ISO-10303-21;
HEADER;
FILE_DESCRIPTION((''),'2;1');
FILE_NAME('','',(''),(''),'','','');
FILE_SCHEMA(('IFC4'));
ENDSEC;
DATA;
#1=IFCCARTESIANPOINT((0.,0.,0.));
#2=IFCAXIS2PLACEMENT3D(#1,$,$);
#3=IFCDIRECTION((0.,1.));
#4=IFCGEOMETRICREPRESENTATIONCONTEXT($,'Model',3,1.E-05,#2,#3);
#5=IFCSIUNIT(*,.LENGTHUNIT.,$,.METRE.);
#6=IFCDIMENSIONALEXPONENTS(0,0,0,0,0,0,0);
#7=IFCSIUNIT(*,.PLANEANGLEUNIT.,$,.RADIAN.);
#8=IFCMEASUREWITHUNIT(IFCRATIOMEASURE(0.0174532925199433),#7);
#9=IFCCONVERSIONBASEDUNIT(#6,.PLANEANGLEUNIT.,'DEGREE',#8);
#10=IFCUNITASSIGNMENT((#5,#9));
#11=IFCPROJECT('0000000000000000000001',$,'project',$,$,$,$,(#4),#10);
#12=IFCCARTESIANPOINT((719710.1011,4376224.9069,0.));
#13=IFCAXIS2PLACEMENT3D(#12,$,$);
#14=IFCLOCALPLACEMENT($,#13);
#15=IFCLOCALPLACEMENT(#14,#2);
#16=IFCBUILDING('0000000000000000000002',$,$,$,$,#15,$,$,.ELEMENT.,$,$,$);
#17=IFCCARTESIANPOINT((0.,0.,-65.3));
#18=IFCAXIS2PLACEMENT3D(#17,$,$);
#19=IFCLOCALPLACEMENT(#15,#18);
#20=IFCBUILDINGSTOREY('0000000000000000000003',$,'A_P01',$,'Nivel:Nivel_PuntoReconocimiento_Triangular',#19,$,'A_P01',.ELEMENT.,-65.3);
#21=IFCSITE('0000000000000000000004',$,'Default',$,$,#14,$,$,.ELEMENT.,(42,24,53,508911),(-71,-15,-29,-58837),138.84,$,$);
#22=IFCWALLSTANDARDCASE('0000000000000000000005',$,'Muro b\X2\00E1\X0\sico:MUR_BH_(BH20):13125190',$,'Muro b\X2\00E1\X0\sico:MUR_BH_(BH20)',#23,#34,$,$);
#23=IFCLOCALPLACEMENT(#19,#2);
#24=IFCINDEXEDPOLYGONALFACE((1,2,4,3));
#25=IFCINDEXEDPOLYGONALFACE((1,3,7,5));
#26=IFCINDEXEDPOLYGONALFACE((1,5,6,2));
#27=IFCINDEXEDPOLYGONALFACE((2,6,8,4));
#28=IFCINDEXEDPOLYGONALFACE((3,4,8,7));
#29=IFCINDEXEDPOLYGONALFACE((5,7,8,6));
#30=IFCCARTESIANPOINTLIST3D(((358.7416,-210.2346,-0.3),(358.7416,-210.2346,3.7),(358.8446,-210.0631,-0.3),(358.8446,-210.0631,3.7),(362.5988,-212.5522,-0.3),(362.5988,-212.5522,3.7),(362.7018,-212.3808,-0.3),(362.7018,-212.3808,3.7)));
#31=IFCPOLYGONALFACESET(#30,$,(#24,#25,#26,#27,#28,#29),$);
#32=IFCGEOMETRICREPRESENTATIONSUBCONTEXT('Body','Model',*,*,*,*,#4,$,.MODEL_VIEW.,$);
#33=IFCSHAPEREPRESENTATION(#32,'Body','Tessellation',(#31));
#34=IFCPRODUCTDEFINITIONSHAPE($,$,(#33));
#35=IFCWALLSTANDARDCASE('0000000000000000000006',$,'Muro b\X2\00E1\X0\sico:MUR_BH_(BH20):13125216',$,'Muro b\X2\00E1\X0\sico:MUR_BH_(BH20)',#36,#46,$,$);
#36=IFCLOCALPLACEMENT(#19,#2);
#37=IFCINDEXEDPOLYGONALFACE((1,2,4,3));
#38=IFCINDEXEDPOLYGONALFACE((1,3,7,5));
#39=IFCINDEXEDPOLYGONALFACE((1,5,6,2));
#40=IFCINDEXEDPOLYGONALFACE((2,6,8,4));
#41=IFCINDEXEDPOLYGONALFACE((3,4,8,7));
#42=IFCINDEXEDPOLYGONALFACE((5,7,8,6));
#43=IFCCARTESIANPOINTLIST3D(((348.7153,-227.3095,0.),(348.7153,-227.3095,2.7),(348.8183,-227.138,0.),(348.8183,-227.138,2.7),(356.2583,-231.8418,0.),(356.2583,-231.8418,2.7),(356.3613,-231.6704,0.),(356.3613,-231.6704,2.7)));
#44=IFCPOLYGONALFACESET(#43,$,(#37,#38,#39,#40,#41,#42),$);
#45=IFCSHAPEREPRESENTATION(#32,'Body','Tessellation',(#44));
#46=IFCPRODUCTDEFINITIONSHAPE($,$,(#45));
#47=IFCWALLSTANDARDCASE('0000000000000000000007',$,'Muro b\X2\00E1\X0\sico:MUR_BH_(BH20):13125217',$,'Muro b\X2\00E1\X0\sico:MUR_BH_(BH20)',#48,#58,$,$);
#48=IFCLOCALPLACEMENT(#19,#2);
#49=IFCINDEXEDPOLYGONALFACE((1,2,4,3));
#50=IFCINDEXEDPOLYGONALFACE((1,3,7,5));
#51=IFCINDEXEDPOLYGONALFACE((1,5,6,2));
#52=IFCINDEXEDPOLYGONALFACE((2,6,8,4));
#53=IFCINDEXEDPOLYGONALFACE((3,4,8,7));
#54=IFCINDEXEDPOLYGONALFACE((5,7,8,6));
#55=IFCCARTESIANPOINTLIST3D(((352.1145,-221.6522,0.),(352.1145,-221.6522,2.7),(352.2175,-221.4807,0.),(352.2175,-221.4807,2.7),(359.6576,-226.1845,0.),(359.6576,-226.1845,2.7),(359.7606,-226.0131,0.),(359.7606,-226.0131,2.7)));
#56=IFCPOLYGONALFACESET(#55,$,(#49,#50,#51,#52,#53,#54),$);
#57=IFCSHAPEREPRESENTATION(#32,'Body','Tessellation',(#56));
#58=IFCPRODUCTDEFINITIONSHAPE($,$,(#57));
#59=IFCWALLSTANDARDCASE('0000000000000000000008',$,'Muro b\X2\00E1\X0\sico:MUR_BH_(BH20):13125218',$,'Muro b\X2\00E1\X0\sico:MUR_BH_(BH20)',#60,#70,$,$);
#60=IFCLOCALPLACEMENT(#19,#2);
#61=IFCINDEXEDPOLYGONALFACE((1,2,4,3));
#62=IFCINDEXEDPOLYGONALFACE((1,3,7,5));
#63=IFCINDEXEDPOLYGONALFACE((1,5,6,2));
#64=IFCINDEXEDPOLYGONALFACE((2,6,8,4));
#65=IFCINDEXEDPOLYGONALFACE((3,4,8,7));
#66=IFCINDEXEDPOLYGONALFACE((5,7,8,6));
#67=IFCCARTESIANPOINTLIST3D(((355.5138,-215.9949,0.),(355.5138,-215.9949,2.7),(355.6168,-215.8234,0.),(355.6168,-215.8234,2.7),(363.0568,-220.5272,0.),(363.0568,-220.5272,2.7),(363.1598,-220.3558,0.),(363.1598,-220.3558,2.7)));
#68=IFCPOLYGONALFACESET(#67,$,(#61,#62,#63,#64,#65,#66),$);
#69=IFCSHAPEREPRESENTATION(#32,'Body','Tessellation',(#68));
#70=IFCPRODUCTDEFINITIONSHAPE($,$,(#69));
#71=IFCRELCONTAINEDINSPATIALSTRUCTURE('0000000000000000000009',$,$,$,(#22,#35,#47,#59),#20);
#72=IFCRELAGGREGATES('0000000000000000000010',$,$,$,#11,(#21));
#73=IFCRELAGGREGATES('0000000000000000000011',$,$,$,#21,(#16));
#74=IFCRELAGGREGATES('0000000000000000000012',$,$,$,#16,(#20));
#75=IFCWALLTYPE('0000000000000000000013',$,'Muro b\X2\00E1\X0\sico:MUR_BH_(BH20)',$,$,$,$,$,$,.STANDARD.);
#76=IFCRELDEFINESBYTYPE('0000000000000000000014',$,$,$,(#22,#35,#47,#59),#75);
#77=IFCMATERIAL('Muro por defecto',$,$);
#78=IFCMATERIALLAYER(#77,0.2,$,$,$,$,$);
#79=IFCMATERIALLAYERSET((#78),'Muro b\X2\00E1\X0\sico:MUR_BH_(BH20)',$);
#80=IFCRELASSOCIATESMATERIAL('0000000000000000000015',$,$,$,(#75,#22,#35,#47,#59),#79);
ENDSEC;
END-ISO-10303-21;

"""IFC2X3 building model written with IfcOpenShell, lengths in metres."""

from ifc_helpers import new_model, entity, si_unit, converted_unit, direction, frame, frame_2d, origin, place, context, subcontext, project, spatial, rectangle, extrude, material, layer, layer_set, layer_usage, type_object, element, save


model = new_model("IFC2X3")

# Units and contexts
model_context = context("Model", 3, precision=1e-05, world=origin(), true_north=direction((0.0, 1.0)))
body_context = subcontext(model_context, "Body", "Model", "MODEL_VIEW")
ifc_project = project(units=[si_unit("LENGTHUNIT", "METRE"), converted_unit("PLANEANGLEUNIT", "DEGREE", entity("IfcRatioMeasure", 0.0174532925199433), si_unit("PLANEANGLEUNIT", "RADIAN"), dimensions=[0, 0, 0, 0, 0, 0, 0])], contexts=[model_context])

# Site, building, storey
site_placement = place(None, frame((719710.1011, 4376224.9069, 0.0)))
site = spatial("IfcSite", under=ifc_project, at=site_placement, Name="Default", CompositionType="ELEMENT", RefLatitude=(42, 24, 53, 508911), RefLongitude=(-71, -15, -29, -58837), RefElevation=138.84)
building_placement = place(site_placement, origin())
building = spatial("IfcBuilding", under=site, at=building_placement, CompositionType="ELEMENT")
storey_placement = place(building_placement, frame((0.0, 0.0, -65.3)))
storey = spatial("IfcBuildingStorey", under=building, at=storey_placement, Name="A_P01", ObjectType="Nivel:Nivel_PuntoReconocimiento_Triangular", LongName="A_P01", CompositionType="ELEMENT", Elevation=-65.3)

# Walls
ifc_material_1 = material(Name="Muro por defecto")
ifc_layer = layer(ifc_material_1, 0.2)
ifc_layer_set = layer_set([ifc_layer], Name="Muro básico:MUR_BH_(BH20)")
ifc_layer_usage_1 = layer_usage(ifc_layer_set, "AXIS2", "NEGATIVE", 0.1)
wall_type = type_object("IfcWallType", Name="Muro básico:MUR_BH_(BH20)", PredefinedType="STANDARD", material=ifc_layer_set)
wall_1_placement = place(storey_placement, frame((358.7931, -210.1488, -0.3), z_axis=(0.0, 0.0, 1.0), x_axis=(0.857167, -0.515038, 0.0)))
element("IfcWallStandardCase", 1, at=wall_1_placement, inside=storey, type_object=wall_type, material=ifc_layer_usage_1, Name="Muro básico:MUR_BH_(BH20):13125190", ObjectType="Muro básico:MUR_BH_(BH20)", context=body_context, shape_type="SweptSolid", body=[
    extrude(rectangle(XDim=4.5, YDim=0.2, at=frame_2d((2.25, 0.0), x_axis=(-1.0, 0.0))), origin(), (0.0, 0.0, 1.0), 4.0),
])
ifc_layer_usage_2 = layer_usage(ifc_layer_set, "AXIS2", "NEGATIVE", 0.1)
wall_2_placement = place(storey_placement, frame((348.7668, -227.2238, 0.0), z_axis=(0.0, 0.0, 1.0), x_axis=(0.857167, -0.515038, 0.0)))
element("IfcWallStandardCase", 2, at=wall_2_placement, inside=storey, type_object=wall_type, material=ifc_layer_usage_2, Name="Muro básico:MUR_BH_(BH20):13125216", ObjectType="Muro básico:MUR_BH_(BH20)", context=body_context, shape_type="SweptSolid", body=[
    extrude(rectangle(XDim=8.8, YDim=0.2, at=frame_2d((4.4, 0.0), x_axis=(-1.0, 0.0))), origin(), (0.0, 0.0, 1.0), 2.7),
])
ifc_layer_usage_3 = layer_usage(ifc_layer_set, "AXIS2", "NEGATIVE", 0.1)
wall_3_placement = place(storey_placement, frame((352.166, -221.5665, 0.0), z_axis=(0.0, 0.0, 1.0), x_axis=(0.857167, -0.515038, 0.0)))
element("IfcWallStandardCase", 3, at=wall_3_placement, inside=storey, type_object=wall_type, material=ifc_layer_usage_3, Name="Muro básico:MUR_BH_(BH20):13125217", ObjectType="Muro básico:MUR_BH_(BH20)", context=body_context, shape_type="SweptSolid", body=[
    extrude(rectangle(XDim=8.8, YDim=0.2, at=frame_2d((4.4, 0.0), x_axis=(-1.0, 0.0))), origin(), (0.0, 0.0, 1.0), 2.7),
])
ifc_layer_usage_4 = layer_usage(ifc_layer_set, "AXIS2", "NEGATIVE", 0.1)
wall_4_placement = place(storey_placement, frame((355.5653, -215.9092, 0.0), z_axis=(0.0, 0.0, 1.0), x_axis=(0.857167, -0.515038, 0.0)))
element("IfcWallStandardCase", 4, at=wall_4_placement, inside=storey, type_object=wall_type, material=ifc_layer_usage_4, Name="Muro básico:MUR_BH_(BH20):13125218", ObjectType="Muro básico:MUR_BH_(BH20)", context=body_context, shape_type="SweptSolid", body=[
    extrude(rectangle(XDim=8.8, YDim=0.2, at=frame_2d((4.4, 0.0), x_axis=(-1.0, 0.0))), origin(), (0.0, 0.0, 1.0), 2.7),
])

save(model, "model.ifc")
